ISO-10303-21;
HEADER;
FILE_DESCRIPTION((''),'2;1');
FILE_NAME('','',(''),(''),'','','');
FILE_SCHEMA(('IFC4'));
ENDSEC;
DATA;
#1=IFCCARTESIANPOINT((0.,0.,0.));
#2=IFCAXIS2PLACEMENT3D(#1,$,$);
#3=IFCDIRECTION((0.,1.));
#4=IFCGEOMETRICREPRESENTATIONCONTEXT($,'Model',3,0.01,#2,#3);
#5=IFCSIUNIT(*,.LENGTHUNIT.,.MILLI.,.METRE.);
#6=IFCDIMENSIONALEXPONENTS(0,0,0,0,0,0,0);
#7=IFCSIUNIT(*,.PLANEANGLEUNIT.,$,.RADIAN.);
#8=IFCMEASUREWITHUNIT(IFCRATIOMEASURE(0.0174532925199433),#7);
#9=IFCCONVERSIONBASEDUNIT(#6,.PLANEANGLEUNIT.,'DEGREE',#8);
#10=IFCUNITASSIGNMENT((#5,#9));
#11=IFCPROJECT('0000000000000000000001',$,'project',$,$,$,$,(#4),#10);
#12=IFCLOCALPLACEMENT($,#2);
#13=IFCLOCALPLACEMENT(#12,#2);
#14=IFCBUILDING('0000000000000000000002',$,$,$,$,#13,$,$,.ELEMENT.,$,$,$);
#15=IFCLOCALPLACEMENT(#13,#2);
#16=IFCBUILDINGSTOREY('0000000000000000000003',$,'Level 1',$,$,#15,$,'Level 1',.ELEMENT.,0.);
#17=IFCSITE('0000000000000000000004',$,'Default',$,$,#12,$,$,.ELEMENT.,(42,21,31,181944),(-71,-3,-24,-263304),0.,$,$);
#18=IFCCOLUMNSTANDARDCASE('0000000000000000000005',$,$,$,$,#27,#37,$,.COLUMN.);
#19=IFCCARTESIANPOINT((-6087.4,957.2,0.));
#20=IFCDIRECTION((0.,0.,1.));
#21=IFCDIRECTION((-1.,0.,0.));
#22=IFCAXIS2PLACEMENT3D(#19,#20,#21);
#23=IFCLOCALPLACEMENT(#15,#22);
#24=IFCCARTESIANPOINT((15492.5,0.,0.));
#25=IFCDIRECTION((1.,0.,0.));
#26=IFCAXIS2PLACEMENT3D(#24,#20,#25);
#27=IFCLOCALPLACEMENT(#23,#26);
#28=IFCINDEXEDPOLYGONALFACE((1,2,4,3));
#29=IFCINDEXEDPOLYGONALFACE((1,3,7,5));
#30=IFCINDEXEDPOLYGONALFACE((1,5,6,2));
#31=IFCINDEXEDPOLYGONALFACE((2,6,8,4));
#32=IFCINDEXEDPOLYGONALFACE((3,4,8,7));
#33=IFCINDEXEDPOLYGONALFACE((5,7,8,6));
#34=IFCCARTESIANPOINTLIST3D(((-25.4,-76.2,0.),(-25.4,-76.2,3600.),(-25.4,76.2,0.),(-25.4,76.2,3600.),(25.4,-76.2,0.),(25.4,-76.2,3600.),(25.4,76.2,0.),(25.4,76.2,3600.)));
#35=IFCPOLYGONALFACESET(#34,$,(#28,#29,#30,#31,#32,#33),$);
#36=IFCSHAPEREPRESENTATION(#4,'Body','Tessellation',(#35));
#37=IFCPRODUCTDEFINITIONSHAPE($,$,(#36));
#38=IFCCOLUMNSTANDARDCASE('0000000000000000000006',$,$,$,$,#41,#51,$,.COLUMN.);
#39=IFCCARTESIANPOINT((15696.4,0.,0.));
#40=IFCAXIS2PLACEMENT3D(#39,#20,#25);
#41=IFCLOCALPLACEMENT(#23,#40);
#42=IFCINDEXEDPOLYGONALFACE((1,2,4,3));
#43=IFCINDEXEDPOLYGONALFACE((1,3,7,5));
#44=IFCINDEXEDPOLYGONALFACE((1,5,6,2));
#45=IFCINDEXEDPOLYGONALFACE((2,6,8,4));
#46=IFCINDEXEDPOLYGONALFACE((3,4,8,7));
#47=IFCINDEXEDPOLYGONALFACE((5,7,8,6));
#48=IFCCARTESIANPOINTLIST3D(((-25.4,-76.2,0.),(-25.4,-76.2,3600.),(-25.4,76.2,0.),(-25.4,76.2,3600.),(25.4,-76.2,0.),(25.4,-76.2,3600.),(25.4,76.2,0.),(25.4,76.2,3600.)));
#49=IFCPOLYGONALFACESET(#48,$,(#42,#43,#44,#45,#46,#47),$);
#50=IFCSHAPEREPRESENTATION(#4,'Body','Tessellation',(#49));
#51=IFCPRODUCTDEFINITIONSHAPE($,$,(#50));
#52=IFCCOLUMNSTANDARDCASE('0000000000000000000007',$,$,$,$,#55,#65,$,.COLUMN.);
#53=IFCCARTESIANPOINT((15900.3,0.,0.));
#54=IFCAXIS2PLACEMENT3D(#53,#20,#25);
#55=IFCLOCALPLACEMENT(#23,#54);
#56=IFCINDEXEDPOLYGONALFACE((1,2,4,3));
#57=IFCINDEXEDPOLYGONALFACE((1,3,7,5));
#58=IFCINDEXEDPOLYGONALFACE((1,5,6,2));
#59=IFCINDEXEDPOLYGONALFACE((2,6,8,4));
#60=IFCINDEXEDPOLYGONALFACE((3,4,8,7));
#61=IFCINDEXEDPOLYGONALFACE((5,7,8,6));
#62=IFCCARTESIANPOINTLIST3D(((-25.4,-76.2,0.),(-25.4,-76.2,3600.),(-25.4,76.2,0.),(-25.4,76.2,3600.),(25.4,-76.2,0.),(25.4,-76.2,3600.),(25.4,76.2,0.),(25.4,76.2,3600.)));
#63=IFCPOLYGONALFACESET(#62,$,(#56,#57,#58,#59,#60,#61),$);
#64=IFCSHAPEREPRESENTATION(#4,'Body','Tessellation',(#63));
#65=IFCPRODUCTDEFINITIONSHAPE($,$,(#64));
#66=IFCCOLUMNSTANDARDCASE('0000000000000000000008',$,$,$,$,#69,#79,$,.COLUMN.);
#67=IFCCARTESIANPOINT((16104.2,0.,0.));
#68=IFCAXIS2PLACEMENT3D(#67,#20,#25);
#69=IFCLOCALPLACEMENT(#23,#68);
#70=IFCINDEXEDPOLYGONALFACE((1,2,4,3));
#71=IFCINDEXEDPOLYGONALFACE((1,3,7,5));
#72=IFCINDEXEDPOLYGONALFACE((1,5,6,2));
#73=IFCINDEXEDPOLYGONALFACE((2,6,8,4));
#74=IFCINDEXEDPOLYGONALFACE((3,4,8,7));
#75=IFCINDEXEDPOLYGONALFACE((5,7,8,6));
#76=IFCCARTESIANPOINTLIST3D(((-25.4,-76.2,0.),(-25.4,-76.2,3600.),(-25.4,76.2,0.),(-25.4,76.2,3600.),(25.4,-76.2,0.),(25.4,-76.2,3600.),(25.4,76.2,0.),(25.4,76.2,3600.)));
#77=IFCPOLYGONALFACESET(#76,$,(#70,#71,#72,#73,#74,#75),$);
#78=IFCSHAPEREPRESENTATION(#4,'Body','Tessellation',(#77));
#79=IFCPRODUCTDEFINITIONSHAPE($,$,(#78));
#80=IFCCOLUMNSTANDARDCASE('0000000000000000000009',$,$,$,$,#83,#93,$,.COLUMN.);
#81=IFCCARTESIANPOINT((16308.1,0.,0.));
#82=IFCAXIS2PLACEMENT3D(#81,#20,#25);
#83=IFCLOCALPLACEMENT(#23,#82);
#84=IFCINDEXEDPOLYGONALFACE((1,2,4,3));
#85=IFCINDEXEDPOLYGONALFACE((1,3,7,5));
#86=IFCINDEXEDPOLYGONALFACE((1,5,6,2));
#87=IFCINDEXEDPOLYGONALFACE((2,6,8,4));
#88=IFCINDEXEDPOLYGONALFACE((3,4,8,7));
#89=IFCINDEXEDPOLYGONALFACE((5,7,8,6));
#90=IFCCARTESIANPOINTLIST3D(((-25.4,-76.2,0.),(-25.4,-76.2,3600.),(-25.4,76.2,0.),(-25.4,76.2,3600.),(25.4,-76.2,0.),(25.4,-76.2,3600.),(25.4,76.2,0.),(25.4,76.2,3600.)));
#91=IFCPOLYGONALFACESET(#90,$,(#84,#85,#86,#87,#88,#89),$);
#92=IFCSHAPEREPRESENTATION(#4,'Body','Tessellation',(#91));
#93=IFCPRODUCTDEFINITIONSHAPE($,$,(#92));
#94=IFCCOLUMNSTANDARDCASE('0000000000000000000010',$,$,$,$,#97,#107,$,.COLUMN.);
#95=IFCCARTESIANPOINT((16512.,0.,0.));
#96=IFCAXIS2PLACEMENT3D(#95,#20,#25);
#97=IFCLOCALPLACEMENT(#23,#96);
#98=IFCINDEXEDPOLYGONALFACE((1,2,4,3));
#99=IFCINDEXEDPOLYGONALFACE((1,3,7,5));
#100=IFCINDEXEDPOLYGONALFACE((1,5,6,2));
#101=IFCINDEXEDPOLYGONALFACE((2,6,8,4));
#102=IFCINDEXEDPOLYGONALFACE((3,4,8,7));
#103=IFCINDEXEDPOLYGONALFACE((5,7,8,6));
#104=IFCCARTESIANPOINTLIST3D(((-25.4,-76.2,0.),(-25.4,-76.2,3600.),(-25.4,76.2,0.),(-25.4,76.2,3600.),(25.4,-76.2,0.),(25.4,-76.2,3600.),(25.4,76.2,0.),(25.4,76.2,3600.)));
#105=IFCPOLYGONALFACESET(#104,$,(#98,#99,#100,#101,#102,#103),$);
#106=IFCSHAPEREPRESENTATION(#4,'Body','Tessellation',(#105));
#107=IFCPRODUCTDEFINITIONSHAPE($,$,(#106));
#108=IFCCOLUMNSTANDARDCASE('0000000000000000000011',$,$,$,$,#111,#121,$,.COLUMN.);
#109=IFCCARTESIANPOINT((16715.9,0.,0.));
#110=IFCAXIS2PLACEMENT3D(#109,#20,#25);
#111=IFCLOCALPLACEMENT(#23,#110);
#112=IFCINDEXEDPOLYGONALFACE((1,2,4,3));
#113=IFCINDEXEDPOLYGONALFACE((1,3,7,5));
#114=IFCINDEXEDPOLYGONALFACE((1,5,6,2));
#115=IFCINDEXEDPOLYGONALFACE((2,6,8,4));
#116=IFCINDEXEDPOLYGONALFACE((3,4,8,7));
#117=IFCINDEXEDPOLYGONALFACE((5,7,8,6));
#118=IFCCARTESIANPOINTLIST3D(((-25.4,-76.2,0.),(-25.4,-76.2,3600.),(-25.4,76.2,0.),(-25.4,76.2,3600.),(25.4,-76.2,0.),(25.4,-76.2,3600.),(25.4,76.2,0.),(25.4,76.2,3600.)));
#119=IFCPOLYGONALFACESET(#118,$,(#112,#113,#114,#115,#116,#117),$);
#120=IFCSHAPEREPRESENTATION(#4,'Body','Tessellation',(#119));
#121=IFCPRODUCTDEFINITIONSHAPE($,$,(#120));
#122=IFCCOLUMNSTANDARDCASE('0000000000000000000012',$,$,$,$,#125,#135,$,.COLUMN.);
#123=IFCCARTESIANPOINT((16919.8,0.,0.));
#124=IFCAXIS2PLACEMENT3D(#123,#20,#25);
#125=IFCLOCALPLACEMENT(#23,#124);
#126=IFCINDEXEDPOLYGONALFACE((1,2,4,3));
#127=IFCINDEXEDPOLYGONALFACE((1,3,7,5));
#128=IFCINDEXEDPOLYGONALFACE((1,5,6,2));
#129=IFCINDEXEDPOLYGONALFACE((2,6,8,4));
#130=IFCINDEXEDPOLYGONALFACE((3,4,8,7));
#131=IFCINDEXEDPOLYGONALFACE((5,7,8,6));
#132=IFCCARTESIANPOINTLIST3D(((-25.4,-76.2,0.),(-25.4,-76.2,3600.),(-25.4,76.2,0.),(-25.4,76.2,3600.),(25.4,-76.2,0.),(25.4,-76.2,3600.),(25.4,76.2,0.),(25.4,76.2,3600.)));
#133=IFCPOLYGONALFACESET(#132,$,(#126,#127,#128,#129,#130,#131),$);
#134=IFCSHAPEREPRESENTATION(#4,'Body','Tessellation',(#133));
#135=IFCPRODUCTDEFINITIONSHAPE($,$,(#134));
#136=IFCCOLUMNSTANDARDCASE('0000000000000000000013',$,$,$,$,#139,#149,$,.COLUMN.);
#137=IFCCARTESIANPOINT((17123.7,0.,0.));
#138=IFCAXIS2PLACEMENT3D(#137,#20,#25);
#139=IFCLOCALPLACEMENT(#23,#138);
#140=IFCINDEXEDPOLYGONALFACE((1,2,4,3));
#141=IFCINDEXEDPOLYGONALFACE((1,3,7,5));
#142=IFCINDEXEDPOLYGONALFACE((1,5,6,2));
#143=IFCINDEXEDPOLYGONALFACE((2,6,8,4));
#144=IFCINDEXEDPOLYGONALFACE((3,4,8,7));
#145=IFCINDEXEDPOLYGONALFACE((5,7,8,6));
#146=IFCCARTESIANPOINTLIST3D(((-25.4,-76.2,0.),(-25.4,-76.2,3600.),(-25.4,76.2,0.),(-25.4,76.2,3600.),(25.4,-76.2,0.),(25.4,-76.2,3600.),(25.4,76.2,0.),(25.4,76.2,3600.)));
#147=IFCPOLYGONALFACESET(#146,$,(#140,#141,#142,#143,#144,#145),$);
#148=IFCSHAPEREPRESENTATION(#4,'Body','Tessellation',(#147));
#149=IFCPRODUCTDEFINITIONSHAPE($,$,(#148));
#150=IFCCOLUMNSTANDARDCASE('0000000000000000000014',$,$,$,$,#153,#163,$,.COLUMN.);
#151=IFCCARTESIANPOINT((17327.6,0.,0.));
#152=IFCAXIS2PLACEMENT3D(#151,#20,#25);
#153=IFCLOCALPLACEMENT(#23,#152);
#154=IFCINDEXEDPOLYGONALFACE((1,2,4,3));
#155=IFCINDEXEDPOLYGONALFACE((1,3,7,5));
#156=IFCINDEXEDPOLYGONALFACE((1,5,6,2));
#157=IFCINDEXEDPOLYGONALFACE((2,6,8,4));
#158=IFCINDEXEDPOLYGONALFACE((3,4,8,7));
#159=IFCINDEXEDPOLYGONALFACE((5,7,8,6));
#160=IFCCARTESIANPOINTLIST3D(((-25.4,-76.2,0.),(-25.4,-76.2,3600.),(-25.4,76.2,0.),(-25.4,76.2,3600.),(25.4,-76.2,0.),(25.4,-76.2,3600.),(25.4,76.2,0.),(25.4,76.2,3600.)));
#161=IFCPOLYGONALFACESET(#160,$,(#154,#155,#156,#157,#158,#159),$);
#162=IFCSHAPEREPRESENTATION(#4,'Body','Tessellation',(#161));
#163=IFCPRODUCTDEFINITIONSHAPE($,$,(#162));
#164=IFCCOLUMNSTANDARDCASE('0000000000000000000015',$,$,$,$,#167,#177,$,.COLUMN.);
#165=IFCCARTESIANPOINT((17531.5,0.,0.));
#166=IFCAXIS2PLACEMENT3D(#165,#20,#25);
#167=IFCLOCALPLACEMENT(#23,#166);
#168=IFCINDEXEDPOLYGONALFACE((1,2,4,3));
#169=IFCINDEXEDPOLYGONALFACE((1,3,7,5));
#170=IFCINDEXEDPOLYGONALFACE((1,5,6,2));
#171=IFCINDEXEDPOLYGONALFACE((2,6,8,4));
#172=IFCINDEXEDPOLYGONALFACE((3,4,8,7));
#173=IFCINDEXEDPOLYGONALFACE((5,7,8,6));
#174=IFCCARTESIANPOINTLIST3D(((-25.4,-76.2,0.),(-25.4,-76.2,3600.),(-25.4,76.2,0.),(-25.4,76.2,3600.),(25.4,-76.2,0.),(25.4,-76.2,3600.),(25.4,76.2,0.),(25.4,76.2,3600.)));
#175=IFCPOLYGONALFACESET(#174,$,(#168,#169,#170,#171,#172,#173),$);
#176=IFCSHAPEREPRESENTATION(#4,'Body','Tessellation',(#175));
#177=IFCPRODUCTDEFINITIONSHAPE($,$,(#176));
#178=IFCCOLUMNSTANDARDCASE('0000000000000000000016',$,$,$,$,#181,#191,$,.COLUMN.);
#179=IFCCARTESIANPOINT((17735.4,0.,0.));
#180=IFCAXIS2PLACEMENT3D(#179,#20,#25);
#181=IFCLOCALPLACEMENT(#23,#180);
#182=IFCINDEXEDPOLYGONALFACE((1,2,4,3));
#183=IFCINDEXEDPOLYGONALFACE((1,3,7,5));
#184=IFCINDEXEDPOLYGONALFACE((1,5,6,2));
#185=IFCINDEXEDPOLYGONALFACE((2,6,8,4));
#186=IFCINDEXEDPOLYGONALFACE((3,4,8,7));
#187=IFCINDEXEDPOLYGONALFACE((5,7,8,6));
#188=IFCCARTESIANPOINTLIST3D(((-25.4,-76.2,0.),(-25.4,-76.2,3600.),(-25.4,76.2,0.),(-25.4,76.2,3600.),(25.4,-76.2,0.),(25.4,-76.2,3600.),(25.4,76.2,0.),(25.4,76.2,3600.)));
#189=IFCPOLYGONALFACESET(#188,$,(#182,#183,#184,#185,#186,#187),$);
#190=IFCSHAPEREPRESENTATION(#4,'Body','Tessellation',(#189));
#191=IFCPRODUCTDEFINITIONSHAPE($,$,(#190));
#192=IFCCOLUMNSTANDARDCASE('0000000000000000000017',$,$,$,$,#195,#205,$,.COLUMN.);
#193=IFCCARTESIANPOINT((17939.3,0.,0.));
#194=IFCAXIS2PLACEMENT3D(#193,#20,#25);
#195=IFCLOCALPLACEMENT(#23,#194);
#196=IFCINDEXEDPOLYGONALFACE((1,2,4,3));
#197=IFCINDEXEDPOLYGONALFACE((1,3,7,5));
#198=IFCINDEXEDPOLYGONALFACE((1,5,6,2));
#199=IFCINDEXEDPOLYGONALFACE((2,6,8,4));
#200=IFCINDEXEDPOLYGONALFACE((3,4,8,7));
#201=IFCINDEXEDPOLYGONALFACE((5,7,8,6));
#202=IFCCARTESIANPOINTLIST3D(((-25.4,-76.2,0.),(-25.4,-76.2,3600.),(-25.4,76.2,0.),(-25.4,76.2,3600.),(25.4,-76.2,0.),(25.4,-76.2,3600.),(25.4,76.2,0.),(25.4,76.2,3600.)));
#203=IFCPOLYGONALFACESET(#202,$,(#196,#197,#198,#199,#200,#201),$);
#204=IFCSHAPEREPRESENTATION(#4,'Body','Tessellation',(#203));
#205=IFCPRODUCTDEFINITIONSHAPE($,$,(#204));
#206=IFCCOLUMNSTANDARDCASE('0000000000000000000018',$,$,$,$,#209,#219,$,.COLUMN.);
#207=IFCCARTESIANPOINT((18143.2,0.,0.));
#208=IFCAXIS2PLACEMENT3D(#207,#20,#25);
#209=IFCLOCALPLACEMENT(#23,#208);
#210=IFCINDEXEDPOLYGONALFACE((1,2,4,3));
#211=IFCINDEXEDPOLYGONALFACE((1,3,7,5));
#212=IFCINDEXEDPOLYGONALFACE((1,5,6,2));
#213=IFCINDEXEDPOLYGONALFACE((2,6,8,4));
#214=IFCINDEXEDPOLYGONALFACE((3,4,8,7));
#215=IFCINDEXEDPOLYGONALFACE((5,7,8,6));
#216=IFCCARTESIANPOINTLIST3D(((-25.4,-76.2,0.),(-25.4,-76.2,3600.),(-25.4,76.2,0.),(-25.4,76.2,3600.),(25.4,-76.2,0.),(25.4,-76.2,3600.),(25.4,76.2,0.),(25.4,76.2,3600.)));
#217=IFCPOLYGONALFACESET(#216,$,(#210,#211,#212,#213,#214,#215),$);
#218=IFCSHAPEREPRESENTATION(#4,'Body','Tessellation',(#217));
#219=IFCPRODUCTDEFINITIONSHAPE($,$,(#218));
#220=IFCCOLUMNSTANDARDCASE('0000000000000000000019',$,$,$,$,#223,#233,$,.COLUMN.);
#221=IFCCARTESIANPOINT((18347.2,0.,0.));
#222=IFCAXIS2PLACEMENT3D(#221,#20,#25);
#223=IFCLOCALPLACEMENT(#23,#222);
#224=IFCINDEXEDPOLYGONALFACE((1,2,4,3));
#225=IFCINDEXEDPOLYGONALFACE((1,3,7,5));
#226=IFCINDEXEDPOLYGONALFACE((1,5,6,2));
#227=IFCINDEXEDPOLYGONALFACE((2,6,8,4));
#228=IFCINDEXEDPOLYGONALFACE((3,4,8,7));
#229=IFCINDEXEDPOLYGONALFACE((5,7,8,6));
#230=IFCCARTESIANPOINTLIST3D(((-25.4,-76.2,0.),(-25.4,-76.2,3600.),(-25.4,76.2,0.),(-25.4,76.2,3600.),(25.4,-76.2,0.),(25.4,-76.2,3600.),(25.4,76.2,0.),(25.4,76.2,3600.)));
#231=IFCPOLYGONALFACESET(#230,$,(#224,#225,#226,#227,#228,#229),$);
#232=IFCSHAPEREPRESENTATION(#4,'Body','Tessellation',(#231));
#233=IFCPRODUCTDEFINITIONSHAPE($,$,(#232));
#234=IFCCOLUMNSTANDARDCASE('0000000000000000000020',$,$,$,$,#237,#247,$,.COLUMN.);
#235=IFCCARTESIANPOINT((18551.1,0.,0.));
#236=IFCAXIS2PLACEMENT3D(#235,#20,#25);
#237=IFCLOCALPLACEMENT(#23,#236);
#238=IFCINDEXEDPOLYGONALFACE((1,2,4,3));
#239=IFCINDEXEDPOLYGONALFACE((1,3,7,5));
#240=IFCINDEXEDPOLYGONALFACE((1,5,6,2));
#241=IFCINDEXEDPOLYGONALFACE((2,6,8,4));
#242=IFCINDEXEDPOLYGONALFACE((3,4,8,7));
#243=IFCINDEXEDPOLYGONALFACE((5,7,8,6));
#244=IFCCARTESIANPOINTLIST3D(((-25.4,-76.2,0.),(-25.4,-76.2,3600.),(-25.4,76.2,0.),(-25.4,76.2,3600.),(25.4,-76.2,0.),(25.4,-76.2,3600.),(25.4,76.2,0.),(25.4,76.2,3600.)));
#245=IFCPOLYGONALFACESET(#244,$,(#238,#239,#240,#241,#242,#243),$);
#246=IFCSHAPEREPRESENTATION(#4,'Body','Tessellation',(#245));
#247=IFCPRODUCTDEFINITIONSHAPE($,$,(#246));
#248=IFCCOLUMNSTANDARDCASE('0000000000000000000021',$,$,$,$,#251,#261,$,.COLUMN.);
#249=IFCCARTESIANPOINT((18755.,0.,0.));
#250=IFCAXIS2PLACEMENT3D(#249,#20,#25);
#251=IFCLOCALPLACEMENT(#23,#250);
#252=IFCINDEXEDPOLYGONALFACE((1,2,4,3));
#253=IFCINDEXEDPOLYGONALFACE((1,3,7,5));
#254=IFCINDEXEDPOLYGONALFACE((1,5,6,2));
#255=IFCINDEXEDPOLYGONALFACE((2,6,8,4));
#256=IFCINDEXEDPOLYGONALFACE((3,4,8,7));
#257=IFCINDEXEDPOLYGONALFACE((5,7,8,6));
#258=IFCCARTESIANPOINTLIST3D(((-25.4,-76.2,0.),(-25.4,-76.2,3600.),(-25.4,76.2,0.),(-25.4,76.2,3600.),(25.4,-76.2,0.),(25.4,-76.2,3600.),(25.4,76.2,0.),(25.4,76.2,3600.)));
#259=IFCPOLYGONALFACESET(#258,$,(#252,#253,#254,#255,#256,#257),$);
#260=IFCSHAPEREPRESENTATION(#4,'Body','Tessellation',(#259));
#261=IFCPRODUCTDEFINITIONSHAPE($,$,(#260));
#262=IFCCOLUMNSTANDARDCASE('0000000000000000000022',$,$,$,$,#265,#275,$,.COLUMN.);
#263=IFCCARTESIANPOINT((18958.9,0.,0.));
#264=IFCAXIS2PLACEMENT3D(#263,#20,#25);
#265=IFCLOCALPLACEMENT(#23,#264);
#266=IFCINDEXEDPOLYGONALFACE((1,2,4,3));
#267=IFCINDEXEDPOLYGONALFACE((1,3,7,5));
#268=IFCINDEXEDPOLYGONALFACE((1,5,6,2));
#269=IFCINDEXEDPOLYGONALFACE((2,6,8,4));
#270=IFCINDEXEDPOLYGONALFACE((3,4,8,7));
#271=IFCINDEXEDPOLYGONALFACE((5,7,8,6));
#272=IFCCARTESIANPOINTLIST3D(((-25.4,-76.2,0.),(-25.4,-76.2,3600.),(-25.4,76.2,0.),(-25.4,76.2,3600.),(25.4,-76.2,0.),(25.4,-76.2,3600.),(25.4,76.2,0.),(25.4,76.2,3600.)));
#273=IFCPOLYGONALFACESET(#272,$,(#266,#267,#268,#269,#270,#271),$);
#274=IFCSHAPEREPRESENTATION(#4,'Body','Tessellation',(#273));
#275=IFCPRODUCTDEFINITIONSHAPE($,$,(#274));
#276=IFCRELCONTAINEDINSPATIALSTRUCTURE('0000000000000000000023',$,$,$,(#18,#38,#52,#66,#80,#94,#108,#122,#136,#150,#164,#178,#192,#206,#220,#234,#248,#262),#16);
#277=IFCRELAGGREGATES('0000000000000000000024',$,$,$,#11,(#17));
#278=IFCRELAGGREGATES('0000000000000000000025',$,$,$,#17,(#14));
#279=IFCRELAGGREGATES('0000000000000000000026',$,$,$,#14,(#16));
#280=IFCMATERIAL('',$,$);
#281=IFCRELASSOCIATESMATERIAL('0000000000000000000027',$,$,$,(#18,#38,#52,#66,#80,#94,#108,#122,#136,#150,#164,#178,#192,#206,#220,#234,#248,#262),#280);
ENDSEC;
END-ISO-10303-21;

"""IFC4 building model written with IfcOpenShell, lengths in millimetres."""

from ifc_helpers import new_model, entity, si_unit, converted_unit, direction, frame, origin, place, context, project, spatial, rectangle, extrude, material, element, save


model = new_model("IFC4")

# Units and contexts
model_context = context("Model", 3, precision=0.01, world=origin(), true_north=direction((0.0, 1.0)))
ifc_project = project(units=[si_unit("LENGTHUNIT", "METRE", prefix="MILLI"), converted_unit("PLANEANGLEUNIT", "DEGREE", entity("IfcRatioMeasure", 0.0174532925199433), si_unit("PLANEANGLEUNIT", "RADIAN"), dimensions=[0, 0, 0, 0, 0, 0, 0])], contexts=[model_context])

# Site, building, storey
site_placement = place(None, origin())
site = spatial("IfcSite", under=ifc_project, at=site_placement, Name="Default", CompositionType="ELEMENT", RefLatitude=(42, 21, 31, 181944), RefLongitude=(-71, -3, -24, -263304), RefElevation=0.0)
building_placement = place(site_placement, origin())
building = spatial("IfcBuilding", under=site, at=building_placement, CompositionType="ELEMENT")
storey_placement = place(building_placement, origin())
storey = spatial("IfcBuildingStorey", under=building, at=storey_placement, Name="Level 1", LongName="Level 1", CompositionType="ELEMENT", Elevation=0.0)

# Columns
ifc_material_1 = material(Name="")
placement_1 = place(storey_placement, frame((-6087.4, 957.2, 0.0), z_axis=(0.0, 0.0, 1.0), x_axis=(-1.0, 0.0, 0.0)))
for number, where, z_axis, x_axis in (
    (1, (15492.5, 0.0, 0.0), (0.0, 0.0, 1.0), (1.0, 0.0, 0.0)),
    (2, (15696.4, 0.0, 0.0), (0.0, 0.0, 1.0), (1.0, 0.0, 0.0)),
    (3, (15900.3, 0.0, 0.0), (0.0, 0.0, 1.0), (1.0, 0.0, 0.0)),
    (4, (16104.2, 0.0, 0.0), (0.0, 0.0, 1.0), (1.0, 0.0, 0.0)),
    (5, (16308.1, 0.0, 0.0), (0.0, 0.0, 1.0), (1.0, 0.0, 0.0)),
    (6, (16512.0, 0.0, 0.0), (0.0, 0.0, 1.0), (1.0, 0.0, 0.0)),
    (7, (16715.9, 0.0, 0.0), (0.0, 0.0, 1.0), (1.0, 0.0, 0.0)),
    (8, (16919.8, 0.0, 0.0), (0.0, 0.0, 1.0), (1.0, 0.0, 0.0)),
    (9, (17123.7, 0.0, 0.0), (0.0, 0.0, 1.0), (1.0, 0.0, 0.0)),
    (10, (17327.6, 0.0, 0.0), (0.0, 0.0, 1.0), (1.0, 0.0, 0.0)),
    (11, (17531.5, 0.0, 0.0), (0.0, 0.0, 1.0), (1.0, 0.0, 0.0)),
    (12, (17735.4, 0.0, 0.0), (0.0, 0.0, 1.0), (1.0, 0.0, 0.0)),
    (13, (17939.3, 0.0, 0.0), (0.0, 0.0, 1.0), (1.0, 0.0, 0.0)),
    (14, (18143.2, 0.0, 0.0), (0.0, 0.0, 1.0), (1.0, 0.0, 0.0)),
    (15, (18347.2, 0.0, 0.0), (0.0, 0.0, 1.0), (1.0, 0.0, 0.0)),
    (16, (18551.1, 0.0, 0.0), (0.0, 0.0, 1.0), (1.0, 0.0, 0.0)),
    (17, (18755.0, 0.0, 0.0), (0.0, 0.0, 1.0), (1.0, 0.0, 0.0)),
    (18, (18958.9, 0.0, 0.0), (0.0, 0.0, 1.0), (1.0, 0.0, 0.0)),
):
    element("IfcColumnStandardCase", number, at=place(placement_1, frame(where, z_axis=z_axis, x_axis=x_axis)), inside=storey, material=ifc_material_1, PredefinedType="COLUMN", context=model_context, shape_type="SweptSolid", body=[
        extrude(rectangle(XDim=50.8, YDim=152.4), origin(), (0.0, 0.0, 1.0), 3600.0),
    ])

save(model, "model.ifc")
